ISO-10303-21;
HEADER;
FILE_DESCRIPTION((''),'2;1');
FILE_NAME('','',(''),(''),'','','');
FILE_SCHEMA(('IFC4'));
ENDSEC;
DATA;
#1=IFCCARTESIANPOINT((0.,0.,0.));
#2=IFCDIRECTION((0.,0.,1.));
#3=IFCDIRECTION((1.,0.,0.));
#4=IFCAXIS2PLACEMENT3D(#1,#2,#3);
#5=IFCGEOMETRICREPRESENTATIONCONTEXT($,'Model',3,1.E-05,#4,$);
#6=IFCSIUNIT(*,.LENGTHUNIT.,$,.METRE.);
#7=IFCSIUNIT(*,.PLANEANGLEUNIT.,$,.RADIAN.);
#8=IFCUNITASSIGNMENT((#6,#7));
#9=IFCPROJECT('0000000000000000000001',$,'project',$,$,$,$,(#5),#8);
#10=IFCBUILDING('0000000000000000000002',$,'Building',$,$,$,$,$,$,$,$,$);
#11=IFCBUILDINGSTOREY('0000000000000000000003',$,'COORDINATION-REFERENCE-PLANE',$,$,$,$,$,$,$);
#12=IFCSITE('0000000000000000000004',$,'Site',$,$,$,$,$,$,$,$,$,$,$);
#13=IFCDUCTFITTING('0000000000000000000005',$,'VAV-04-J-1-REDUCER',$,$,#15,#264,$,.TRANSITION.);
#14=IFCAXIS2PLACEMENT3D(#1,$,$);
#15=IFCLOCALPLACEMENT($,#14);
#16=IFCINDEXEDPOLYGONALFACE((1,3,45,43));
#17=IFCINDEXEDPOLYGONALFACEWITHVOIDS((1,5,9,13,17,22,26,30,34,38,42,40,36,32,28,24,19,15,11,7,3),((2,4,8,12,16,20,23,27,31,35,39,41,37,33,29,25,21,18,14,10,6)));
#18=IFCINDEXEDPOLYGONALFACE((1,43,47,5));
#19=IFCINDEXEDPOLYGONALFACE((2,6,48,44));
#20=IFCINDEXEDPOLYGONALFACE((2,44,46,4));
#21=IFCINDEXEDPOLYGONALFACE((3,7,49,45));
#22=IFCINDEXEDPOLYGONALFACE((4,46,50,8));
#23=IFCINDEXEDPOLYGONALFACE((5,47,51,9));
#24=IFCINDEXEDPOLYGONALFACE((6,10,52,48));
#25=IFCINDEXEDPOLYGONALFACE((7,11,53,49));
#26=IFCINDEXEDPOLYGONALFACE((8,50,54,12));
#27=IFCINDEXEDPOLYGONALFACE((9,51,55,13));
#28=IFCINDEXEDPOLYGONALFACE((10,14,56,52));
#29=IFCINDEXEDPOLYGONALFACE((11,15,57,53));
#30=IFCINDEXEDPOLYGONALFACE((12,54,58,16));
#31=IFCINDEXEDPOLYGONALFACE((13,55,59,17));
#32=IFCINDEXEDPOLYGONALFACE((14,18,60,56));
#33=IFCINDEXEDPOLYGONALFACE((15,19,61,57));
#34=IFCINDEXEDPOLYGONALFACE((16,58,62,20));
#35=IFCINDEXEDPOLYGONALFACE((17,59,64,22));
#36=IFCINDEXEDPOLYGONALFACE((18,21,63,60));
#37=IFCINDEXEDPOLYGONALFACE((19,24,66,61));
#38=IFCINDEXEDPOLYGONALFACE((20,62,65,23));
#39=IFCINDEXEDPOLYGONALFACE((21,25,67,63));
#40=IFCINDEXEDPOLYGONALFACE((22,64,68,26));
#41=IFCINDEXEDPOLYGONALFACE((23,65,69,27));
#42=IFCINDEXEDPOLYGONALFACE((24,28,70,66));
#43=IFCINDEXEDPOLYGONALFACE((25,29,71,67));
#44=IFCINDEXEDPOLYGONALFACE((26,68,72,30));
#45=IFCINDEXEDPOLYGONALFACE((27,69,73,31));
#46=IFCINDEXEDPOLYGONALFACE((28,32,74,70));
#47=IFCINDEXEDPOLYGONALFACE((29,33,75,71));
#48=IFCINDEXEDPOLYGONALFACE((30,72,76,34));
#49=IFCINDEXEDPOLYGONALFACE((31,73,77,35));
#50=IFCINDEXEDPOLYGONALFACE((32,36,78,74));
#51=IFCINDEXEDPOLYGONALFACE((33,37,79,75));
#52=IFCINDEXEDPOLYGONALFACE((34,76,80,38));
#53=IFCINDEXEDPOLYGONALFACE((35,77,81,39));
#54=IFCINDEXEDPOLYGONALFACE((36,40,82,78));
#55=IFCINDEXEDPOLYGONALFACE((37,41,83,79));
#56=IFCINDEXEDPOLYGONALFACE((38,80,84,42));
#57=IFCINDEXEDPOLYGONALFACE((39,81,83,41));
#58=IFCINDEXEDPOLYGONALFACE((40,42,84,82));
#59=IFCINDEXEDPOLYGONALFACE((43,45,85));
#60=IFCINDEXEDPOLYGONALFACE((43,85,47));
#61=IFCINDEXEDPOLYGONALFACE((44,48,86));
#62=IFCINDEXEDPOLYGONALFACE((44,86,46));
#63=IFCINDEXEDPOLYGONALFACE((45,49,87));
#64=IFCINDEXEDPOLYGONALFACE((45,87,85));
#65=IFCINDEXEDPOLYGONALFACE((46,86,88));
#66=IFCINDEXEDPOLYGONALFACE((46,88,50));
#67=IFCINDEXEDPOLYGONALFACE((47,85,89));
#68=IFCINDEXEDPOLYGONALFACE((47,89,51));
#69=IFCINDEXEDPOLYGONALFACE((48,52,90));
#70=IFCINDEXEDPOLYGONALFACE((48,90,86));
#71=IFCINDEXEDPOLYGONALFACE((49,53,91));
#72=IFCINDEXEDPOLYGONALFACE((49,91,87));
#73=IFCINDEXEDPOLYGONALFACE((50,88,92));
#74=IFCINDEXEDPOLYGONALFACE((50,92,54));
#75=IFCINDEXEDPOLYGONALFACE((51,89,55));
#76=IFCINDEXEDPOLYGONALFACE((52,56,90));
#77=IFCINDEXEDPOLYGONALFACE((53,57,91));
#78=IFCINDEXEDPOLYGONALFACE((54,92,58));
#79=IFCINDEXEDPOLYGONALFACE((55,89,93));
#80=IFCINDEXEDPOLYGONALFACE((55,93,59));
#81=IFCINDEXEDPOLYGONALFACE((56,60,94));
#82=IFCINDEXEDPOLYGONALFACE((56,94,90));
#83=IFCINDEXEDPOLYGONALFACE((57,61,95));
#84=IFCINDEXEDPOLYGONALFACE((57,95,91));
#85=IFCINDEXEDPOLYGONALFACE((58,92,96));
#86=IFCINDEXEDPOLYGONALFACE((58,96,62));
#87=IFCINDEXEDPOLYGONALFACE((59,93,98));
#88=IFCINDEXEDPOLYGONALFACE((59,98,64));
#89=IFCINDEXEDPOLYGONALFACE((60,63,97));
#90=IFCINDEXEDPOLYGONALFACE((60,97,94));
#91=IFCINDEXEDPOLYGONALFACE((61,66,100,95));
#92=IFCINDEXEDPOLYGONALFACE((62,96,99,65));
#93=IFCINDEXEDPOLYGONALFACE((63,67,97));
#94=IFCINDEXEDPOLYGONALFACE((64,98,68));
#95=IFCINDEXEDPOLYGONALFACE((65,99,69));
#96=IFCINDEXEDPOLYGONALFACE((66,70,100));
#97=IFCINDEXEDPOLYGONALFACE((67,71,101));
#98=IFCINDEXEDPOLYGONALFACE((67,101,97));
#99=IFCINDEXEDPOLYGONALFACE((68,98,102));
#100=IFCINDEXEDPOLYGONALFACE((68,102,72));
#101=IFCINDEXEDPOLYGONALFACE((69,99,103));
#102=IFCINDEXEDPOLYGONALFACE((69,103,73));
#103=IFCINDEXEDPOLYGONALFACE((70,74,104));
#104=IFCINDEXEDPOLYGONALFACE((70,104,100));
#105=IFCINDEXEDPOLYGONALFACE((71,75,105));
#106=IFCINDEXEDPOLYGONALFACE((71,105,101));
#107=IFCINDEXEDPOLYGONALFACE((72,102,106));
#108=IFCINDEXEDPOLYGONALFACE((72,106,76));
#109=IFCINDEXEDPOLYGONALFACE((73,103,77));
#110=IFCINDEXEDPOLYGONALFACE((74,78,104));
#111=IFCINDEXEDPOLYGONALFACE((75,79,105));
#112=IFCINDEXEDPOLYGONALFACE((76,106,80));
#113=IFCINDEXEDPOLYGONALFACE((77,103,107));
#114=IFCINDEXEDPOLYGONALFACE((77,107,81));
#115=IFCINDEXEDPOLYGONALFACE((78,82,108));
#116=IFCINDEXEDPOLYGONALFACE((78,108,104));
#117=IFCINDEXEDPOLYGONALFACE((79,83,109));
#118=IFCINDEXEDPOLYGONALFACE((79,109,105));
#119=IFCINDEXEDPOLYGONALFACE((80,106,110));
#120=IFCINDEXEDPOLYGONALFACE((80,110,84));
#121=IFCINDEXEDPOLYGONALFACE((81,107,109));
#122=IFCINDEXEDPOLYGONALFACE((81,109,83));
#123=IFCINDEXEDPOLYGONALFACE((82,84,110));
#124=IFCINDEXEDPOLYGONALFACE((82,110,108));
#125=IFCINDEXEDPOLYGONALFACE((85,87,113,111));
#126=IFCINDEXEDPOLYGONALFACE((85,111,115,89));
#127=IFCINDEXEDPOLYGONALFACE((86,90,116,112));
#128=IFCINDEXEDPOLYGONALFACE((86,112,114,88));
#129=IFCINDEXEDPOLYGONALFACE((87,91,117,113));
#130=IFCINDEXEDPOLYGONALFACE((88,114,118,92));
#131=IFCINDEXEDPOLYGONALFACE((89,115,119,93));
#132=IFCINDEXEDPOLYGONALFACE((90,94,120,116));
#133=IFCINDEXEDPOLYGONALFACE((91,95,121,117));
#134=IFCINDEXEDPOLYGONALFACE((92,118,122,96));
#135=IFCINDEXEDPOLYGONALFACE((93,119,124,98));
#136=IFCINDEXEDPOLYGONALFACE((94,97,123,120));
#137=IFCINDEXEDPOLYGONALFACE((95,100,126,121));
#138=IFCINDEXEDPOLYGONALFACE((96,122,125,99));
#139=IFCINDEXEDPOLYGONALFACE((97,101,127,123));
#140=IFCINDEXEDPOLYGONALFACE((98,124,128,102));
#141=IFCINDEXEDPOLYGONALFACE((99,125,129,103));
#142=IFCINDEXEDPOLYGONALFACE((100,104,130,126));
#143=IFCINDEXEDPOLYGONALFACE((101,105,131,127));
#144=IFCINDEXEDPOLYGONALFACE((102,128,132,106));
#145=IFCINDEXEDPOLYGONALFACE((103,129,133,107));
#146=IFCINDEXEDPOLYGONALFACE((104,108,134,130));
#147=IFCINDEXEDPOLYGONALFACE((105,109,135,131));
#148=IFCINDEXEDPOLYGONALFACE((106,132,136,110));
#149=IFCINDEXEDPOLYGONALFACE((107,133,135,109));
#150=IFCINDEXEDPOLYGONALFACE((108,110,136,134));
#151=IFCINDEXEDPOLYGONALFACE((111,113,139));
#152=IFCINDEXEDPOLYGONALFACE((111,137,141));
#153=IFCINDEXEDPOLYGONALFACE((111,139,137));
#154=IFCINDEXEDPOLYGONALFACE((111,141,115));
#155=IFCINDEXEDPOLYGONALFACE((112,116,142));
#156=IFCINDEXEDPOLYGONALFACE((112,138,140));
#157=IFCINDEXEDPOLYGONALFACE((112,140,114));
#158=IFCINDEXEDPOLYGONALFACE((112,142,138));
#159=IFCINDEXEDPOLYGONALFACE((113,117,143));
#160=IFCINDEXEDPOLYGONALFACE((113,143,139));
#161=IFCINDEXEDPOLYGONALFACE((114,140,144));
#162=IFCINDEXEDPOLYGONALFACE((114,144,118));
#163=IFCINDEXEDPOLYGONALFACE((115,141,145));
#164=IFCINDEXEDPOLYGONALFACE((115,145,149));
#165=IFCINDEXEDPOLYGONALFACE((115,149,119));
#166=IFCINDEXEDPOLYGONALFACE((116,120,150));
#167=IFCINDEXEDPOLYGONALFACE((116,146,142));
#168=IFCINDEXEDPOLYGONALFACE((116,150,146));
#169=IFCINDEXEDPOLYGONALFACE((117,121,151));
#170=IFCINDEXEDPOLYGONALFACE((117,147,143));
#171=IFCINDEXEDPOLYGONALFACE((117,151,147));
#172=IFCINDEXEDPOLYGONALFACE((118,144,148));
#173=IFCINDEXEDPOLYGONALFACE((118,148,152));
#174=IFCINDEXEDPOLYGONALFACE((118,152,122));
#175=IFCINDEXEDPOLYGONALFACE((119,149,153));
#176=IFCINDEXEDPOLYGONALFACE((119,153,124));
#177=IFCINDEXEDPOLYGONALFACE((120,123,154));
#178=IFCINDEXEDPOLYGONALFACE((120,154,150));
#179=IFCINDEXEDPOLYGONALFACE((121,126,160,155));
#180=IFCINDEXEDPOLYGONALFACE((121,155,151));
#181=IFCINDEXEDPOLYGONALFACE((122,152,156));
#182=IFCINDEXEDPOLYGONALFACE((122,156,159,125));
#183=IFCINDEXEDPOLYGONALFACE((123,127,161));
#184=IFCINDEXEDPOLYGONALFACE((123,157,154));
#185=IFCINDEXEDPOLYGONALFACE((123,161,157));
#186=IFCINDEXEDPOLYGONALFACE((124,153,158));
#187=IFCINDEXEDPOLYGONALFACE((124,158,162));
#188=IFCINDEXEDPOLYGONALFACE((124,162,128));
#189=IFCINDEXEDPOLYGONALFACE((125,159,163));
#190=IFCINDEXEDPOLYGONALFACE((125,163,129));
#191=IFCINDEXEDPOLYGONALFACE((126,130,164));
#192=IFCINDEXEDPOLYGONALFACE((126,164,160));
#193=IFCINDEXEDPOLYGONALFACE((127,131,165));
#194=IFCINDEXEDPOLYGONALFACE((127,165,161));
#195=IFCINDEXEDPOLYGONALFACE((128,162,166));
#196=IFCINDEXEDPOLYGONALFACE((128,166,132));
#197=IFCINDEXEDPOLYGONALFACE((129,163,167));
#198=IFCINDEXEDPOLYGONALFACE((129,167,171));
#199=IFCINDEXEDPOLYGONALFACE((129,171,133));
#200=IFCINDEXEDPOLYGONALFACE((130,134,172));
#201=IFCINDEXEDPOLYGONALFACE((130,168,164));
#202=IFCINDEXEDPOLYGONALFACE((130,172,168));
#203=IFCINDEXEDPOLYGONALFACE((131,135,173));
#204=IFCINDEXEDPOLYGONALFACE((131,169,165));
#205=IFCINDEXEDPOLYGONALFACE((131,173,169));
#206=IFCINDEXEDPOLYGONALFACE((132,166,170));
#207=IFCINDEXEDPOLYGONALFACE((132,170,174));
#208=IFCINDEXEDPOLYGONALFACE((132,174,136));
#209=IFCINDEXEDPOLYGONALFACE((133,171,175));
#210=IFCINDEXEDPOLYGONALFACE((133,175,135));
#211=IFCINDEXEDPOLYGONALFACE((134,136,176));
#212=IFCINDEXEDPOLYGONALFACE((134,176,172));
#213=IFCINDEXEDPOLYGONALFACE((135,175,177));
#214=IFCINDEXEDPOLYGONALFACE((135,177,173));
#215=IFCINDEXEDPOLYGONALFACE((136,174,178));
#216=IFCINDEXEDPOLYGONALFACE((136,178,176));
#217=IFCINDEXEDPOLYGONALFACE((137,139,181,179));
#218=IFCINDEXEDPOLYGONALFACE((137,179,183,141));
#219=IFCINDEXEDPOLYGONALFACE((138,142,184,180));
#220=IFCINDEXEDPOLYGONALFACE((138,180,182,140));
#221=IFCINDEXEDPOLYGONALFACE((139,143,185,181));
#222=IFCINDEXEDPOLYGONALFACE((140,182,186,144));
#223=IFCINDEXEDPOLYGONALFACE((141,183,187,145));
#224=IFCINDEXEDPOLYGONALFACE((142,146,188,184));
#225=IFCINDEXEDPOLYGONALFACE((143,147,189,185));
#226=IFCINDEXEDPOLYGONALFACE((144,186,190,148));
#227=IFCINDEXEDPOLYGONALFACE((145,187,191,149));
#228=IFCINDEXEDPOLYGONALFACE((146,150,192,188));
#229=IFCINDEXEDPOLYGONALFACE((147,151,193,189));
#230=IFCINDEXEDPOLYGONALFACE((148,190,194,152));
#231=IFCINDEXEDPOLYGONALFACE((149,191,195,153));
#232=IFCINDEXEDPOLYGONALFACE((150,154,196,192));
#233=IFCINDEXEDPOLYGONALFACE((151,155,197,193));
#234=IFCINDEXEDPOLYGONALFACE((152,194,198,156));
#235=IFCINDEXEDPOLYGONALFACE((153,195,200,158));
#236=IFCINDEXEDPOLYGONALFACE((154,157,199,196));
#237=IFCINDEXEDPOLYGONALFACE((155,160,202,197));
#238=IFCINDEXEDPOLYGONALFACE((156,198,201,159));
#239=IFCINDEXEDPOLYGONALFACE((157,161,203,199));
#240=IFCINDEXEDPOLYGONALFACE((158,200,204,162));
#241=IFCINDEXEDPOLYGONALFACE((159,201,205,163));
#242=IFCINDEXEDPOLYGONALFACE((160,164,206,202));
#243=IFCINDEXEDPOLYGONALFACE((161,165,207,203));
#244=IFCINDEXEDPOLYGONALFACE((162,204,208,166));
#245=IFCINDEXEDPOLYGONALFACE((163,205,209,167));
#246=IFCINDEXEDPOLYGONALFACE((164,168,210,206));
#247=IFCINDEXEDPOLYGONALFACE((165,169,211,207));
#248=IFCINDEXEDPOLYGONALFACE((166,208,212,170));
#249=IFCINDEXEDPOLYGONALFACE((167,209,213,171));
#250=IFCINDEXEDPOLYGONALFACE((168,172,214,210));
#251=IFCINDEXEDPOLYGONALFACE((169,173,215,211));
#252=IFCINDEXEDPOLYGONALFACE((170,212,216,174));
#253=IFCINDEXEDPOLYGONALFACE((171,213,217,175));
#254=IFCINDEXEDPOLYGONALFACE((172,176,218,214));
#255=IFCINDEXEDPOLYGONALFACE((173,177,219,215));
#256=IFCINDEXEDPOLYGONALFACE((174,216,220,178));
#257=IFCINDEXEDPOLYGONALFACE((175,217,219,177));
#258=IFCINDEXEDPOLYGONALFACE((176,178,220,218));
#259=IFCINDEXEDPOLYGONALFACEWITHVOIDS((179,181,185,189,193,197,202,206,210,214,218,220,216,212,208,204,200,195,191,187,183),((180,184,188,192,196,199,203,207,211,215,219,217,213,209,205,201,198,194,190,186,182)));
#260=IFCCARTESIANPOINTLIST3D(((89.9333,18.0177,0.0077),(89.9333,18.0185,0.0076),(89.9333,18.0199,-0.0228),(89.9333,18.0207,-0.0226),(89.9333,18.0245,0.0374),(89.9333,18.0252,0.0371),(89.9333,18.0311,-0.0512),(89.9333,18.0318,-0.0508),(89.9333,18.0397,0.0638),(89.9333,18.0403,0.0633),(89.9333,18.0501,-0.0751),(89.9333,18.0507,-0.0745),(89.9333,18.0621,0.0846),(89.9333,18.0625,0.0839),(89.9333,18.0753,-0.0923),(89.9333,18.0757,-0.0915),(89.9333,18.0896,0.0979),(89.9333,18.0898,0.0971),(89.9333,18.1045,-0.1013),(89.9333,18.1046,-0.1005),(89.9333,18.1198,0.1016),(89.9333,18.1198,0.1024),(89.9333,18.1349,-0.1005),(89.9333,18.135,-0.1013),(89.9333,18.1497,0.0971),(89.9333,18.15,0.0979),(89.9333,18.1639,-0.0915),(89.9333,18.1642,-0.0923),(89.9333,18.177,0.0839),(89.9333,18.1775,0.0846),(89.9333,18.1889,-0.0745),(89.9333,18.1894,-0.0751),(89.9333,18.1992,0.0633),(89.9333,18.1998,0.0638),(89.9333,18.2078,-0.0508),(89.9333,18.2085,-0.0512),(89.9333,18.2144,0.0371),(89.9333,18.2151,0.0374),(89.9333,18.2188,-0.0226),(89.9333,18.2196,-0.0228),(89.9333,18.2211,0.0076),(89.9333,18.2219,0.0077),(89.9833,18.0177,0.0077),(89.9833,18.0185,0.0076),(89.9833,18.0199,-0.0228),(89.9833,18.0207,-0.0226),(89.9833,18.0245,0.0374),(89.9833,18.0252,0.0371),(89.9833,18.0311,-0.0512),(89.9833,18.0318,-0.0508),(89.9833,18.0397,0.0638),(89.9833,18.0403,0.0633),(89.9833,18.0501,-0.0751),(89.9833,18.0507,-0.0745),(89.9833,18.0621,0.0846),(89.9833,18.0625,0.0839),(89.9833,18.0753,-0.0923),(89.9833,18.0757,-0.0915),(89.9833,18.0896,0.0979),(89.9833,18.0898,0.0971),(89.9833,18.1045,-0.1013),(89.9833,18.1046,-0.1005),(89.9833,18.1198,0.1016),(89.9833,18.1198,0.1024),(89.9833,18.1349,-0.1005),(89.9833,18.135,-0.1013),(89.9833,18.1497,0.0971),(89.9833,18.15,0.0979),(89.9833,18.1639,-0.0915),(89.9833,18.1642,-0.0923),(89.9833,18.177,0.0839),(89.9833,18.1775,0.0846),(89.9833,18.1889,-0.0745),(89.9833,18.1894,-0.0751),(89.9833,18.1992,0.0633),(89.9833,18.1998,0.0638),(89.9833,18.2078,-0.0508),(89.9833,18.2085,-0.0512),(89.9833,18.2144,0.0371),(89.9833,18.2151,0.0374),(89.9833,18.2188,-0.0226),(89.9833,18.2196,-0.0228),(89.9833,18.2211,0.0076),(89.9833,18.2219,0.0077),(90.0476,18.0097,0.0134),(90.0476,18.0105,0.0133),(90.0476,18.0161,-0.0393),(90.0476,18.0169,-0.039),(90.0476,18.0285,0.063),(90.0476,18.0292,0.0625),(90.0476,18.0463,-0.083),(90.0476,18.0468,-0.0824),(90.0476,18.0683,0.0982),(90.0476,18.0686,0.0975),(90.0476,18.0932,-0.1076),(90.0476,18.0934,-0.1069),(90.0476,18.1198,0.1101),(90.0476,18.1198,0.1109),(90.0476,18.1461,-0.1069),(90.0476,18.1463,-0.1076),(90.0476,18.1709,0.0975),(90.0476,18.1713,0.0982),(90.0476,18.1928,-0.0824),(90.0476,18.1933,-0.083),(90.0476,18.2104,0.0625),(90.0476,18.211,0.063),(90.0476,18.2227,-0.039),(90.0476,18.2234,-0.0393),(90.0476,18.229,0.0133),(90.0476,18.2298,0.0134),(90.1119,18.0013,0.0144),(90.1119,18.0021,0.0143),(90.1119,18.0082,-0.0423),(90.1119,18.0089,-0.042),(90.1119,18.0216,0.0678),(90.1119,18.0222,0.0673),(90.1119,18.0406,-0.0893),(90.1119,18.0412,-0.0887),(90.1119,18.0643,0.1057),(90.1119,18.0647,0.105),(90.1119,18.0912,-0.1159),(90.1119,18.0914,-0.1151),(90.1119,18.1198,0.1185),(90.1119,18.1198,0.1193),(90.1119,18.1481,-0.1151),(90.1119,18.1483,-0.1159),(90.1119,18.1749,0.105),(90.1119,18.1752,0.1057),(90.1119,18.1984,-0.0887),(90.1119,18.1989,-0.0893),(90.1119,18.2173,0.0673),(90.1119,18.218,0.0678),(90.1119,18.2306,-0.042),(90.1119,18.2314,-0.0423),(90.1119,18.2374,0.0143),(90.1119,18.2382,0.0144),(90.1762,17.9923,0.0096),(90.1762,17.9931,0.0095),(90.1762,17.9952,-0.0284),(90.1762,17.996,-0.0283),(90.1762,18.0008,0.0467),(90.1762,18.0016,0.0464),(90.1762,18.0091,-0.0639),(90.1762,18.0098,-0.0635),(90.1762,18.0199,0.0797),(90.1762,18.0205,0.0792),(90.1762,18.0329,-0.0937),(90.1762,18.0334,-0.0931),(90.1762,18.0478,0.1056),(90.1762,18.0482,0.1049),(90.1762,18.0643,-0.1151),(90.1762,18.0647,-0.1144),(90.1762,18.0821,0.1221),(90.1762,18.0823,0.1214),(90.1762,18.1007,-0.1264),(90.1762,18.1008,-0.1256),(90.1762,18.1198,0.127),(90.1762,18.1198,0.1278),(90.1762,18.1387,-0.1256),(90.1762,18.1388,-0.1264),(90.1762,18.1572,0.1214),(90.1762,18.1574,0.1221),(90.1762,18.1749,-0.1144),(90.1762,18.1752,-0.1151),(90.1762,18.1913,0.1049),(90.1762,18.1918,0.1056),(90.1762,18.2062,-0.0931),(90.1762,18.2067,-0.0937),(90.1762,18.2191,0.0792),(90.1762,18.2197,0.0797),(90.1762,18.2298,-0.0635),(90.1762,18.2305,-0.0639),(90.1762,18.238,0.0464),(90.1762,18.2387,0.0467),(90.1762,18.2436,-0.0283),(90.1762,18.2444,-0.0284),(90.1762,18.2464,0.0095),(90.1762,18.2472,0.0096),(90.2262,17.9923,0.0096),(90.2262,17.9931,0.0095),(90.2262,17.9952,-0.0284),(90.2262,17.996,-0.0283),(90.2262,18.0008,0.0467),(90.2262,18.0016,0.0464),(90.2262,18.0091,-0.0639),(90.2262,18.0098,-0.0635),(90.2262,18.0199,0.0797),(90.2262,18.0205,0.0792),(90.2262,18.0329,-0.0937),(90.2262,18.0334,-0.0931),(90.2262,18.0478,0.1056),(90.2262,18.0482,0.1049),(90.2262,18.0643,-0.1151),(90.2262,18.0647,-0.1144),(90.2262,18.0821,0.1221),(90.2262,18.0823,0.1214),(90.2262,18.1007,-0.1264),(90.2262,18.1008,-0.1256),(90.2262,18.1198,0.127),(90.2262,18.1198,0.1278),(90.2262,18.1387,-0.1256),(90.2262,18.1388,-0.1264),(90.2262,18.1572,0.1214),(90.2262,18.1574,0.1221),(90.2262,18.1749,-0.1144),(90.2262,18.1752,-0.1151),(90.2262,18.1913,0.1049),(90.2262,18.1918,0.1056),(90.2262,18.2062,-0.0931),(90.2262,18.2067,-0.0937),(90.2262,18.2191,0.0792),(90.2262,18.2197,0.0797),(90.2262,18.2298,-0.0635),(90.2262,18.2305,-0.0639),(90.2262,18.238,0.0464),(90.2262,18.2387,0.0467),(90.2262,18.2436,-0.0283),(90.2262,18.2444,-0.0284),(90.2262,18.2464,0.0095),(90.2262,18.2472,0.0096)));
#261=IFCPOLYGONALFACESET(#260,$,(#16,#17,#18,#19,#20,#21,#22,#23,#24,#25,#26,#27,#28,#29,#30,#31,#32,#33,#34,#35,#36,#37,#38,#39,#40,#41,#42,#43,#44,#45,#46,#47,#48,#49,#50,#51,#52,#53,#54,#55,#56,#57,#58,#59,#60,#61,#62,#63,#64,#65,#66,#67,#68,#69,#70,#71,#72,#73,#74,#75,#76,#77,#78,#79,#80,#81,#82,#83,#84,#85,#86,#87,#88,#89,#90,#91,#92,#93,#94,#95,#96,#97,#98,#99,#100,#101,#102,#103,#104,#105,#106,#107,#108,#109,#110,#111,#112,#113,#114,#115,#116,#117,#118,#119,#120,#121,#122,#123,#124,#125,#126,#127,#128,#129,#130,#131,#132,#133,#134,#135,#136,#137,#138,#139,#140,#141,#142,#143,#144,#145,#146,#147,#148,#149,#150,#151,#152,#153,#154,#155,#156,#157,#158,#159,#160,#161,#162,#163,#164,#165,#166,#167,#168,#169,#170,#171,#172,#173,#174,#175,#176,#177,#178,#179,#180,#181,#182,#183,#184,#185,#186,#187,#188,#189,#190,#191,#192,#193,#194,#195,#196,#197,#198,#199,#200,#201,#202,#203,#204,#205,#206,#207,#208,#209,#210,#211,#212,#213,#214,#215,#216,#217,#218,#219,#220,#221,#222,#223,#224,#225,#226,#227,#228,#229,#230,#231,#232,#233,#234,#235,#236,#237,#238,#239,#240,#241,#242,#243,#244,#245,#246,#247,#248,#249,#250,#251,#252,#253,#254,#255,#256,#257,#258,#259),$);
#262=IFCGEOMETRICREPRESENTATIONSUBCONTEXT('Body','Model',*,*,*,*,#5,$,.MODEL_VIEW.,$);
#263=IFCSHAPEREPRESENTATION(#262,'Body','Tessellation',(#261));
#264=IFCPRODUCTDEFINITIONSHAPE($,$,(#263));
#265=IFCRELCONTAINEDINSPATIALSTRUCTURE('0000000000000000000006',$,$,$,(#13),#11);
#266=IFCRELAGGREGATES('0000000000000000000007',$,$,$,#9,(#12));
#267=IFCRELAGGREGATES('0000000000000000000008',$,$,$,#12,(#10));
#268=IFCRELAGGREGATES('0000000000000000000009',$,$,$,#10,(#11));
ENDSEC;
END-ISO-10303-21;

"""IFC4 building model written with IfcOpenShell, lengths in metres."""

from ifc_helpers import new_model, entity, si_unit, frame, origin_with_axes, place, context, subcontext, project, spatial, element, save


model = new_model("IFC4")

# Units and contexts
model_context = context("Model", 3, precision=1e-05, world=origin_with_axes())
body_context_1 = subcontext(model_context, "Body", "Model", "MODEL_VIEW")
ifc_project = project(units=[si_unit("LENGTHUNIT", "METRE"), si_unit("PLANEANGLEUNIT", "RADIAN")], contexts=[model_context])

# Site, building, storey
site = spatial("IfcSite", under=ifc_project, Name="Site")
building = spatial("IfcBuilding", under=site, Name="Building")
storey = spatial("IfcBuildingStorey", under=building, Name="COORDINATION-REFERENCE-PLANE")

# Duct fitting
for number, where, z_axis, x_axis, name in (
    (1, (90.2262, 18.1198, 0.0), (0.0, -1.0, 0.0), (0.0, 0.0, 1.0), "VAV-04-J-1-REDUCER"),
):
    element("IfcDuctFitting", number, at=place(None, frame(where, z_axis=z_axis, x_axis=x_axis)), inside=storey, Name=name, PredefinedType="TRANSITION", context=body_context_1, shape_type="SweptSolid", body=[
        entity("IfcRevolvedAreaSolid", entity("IfcArbitraryClosedProfileDef", "AREA", None, entity("IfcPolyline", [entity("IfcCartesianPoint", [0.1278, 0.0]), entity("IfcCartesianPoint", [0.1278, 0.05]), entity("IfcCartesianPoint", [0.1024, 0.2429]), entity("IfcCartesianPoint", [0.1024, 0.2929]), entity("IfcCartesianPoint", [0.1016, 0.2929]), entity("IfcCartesianPoint", [0.1016, 0.2429]), entity("IfcCartesianPoint", [0.127, 0.05]), entity("IfcCartesianPoint", [0.127, 0.0]), entity("IfcCartesianPoint", [0.1278, 0.0])])), entity("IfcAxis2Placement3D", entity("IfcCartesianPoint", [0.0, 0.0, 0.0])), entity("IfcAxis1Placement", entity("IfcCartesianPoint", [0.0, 0.0, 0.0]), entity("IfcDirection", [0.0, 1.0, 0.0])), 6.283185),
    ])

save(model, "model.ifc")
